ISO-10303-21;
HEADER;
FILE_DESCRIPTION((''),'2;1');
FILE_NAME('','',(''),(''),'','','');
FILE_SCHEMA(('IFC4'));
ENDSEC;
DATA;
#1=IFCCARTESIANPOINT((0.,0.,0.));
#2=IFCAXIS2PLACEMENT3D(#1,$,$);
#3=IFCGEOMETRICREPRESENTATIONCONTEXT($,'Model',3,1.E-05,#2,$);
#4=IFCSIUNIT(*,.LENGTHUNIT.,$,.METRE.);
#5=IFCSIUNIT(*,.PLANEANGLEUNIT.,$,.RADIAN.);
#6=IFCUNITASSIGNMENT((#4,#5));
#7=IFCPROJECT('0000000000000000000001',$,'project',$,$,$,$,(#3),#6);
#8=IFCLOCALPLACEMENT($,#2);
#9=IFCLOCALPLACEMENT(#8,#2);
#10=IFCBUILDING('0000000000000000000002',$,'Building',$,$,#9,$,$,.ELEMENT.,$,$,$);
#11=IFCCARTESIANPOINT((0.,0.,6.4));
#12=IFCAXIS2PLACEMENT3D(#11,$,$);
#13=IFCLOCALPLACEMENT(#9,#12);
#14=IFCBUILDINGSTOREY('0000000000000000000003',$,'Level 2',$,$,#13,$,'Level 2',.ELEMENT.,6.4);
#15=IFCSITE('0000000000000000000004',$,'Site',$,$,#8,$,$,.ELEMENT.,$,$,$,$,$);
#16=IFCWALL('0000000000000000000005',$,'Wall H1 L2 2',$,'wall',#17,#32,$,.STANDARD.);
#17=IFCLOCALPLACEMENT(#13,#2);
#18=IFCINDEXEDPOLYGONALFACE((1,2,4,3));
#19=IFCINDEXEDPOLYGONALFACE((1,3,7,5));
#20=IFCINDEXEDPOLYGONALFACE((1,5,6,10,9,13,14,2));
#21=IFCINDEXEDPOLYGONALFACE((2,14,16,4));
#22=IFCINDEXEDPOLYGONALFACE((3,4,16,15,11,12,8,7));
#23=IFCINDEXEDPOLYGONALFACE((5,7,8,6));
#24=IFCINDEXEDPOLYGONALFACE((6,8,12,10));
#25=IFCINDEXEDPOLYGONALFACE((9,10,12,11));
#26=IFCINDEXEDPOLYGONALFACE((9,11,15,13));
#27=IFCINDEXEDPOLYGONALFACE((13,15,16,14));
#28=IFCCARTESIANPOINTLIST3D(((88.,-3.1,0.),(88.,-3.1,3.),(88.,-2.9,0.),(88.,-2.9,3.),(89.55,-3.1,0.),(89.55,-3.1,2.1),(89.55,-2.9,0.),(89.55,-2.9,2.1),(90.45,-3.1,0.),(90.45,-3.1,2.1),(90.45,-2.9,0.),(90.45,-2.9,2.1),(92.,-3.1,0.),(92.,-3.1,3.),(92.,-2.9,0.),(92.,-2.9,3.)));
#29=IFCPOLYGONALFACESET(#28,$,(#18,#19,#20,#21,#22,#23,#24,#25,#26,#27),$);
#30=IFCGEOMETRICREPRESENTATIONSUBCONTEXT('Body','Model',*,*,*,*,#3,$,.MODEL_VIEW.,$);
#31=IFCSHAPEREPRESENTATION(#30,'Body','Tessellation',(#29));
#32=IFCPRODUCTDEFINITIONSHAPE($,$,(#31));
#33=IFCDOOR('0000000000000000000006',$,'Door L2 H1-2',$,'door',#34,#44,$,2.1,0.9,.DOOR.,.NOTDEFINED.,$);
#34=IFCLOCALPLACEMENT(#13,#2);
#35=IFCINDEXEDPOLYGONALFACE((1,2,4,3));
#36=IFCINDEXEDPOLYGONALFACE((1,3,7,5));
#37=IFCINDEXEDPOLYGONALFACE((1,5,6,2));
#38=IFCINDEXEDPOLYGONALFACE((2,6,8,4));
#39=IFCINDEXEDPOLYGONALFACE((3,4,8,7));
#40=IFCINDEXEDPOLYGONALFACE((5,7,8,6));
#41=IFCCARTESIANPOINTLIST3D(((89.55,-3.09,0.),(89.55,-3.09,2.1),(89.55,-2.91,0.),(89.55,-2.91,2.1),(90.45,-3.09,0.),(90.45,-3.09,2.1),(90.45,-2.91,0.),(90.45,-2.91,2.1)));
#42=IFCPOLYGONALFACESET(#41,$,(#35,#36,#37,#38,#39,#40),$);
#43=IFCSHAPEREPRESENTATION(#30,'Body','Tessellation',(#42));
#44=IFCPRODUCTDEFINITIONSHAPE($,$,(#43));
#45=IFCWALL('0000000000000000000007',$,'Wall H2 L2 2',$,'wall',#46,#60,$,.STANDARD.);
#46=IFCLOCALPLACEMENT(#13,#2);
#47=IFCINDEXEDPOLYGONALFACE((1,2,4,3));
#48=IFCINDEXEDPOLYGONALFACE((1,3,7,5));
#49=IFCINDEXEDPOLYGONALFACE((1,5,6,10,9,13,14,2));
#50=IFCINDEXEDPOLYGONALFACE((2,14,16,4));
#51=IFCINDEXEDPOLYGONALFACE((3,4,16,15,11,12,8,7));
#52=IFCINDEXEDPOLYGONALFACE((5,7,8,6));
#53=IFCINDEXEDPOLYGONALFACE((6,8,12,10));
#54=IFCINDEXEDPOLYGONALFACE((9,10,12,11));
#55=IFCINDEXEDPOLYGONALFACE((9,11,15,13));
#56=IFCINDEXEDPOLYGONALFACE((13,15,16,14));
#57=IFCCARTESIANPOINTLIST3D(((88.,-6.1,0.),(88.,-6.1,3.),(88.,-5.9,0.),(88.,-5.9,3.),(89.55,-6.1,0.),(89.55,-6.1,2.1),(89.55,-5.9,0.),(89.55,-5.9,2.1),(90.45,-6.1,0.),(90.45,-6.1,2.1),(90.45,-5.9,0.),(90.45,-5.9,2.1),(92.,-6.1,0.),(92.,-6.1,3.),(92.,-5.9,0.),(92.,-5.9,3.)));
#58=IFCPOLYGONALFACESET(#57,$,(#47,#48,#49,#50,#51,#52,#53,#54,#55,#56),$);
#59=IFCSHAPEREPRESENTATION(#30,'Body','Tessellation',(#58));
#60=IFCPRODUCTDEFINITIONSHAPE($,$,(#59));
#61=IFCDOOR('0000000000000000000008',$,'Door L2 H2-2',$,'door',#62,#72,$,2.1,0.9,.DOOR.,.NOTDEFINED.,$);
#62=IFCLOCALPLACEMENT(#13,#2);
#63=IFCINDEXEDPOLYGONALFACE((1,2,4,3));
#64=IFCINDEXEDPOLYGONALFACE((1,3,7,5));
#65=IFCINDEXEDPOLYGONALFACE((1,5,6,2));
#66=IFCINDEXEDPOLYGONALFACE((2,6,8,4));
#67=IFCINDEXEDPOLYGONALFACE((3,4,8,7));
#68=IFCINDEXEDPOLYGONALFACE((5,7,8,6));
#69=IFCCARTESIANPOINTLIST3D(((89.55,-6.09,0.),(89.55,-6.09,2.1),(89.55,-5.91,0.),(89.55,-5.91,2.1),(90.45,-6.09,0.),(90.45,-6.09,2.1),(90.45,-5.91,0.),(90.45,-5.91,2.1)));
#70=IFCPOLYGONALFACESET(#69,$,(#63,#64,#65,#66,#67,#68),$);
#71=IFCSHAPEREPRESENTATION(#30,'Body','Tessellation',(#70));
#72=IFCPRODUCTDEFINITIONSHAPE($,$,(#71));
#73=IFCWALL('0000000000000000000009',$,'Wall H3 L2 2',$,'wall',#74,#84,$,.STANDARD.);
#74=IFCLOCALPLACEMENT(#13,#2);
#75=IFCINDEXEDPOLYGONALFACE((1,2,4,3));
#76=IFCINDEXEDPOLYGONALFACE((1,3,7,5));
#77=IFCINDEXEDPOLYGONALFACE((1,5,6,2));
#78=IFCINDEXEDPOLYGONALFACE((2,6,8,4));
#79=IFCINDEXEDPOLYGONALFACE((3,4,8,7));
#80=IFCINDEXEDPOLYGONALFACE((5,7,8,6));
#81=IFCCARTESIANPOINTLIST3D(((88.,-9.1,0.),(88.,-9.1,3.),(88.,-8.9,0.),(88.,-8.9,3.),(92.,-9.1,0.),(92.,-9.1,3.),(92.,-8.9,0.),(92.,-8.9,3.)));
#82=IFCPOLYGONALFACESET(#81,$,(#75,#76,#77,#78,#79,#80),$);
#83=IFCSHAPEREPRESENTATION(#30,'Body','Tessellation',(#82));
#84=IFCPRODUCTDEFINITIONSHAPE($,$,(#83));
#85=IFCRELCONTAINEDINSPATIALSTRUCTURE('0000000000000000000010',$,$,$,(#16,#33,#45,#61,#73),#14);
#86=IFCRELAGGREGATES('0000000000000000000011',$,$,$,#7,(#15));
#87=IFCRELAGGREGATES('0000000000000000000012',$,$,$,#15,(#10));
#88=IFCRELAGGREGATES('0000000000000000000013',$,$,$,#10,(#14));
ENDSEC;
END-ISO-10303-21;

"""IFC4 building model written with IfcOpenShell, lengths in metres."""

from ifc_helpers import new_model, si_unit, frame, frame_2d, origin, origin_2d, place, context, subcontext, project, spatial, rectangle, extrude, element, fill, save


model = new_model("IFC4")

# Units and contexts
model_context = context("Model", 3, precision=1e-05, world=origin())
body_context = subcontext(model_context, "Body", "Model", "MODEL_VIEW")
ifc_project = project(units=[si_unit("LENGTHUNIT", "METRE"), si_unit("PLANEANGLEUNIT", "RADIAN")], contexts=[model_context])

# Site, building, storey
site_placement = place(None, origin())
site = spatial("IfcSite", under=ifc_project, at=site_placement, Name="Site", CompositionType="ELEMENT")
building_placement = place(site_placement, origin())
building = spatial("IfcBuilding", under=site, at=building_placement, Name="Building", CompositionType="ELEMENT")
storey_placement = place(building_placement, frame((0.0, 0.0, 6.4)))
storey = spatial("IfcBuildingStorey", under=building, at=storey_placement, Name="Level 2", LongName="Level 2", CompositionType="ELEMENT", Elevation=6.4)

# Walls, openings, doors
wall_1_placement = place(storey_placement, frame((88.0, -3.0, 0.0), z_axis=(0.0, 0.0, 1.0), x_axis=(1.0, 0.0, 0.0)))
wall_1 = element("IfcWall", 1, at=wall_1_placement, inside=storey, Name="Wall H1 L2 2", ObjectType="wall", PredefinedType="STANDARD", context=body_context, shape_type="SweptSolid", body=[
    extrude(rectangle(XDim=4.0, YDim=0.2, at=frame_2d((2.0, 0.0))), origin(), (0.0, 0.0, 1.0), 3.0),
])
opening_1_placement = place(storey_placement, frame((90.0, -3.0, 0.0), z_axis=(0.0, 0.0, 1.0), x_axis=(1.0, 0.0, 0.0)))
opening_1 = element("IfcOpeningElement", 2, at=opening_1_placement, cuts=wall_1, ObjectType="Opening", PredefinedType="OPENING", context=body_context, shape_type="SweptSolid", body=[
    extrude(rectangle(XDim=0.9, YDim=0.22, at=origin_2d()), origin(), (0.0, 0.0, 1.0), 2.1),
])
door_1_placement = place(storey_placement, frame((90.0, -3.0, 0.0), z_axis=(0.0, 0.0, 1.0), x_axis=(1.0, 0.0, 0.0)))
door_1 = element("IfcDoor", 3, at=door_1_placement, inside=storey, Name="Door L2 H1-2", ObjectType="door", OperationType="NOTDEFINED", OverallHeight=2.1, OverallWidth=0.9, PredefinedType="DOOR", context=body_context, shape_type="SweptSolid", body=[
    extrude(rectangle(XDim=0.9, YDim=0.18, at=origin_2d()), origin(), (0.0, 0.0, 1.0), 2.1),
])
fill(opening_1, door_1)
wall_2_placement = place(storey_placement, frame((88.0, -6.0, 0.0), z_axis=(0.0, 0.0, 1.0), x_axis=(1.0, 0.0, 0.0)))
wall_2 = element("IfcWall", 4, at=wall_2_placement, inside=storey, Name="Wall H2 L2 2", ObjectType="wall", PredefinedType="STANDARD", context=body_context, shape_type="SweptSolid", body=[
    extrude(rectangle(XDim=4.0, YDim=0.2, at=frame_2d((2.0, 0.0))), origin(), (0.0, 0.0, 1.0), 3.0),
])
opening_2_placement = place(storey_placement, frame((90.0, -6.0, 0.0), z_axis=(0.0, 0.0, 1.0), x_axis=(1.0, 0.0, 0.0)))
opening_2 = element("IfcOpeningElement", 5, at=opening_2_placement, cuts=wall_2, ObjectType="Opening", PredefinedType="OPENING", context=body_context, shape_type="SweptSolid", body=[
    extrude(rectangle(XDim=0.9, YDim=0.22, at=origin_2d()), origin(), (0.0, 0.0, 1.0), 2.1),
])
door_2_placement = place(storey_placement, frame((90.0, -6.0, 0.0), z_axis=(0.0, 0.0, 1.0), x_axis=(1.0, 0.0, 0.0)))
door_2 = element("IfcDoor", 6, at=door_2_placement, inside=storey, Name="Door L2 H2-2", ObjectType="door", OperationType="NOTDEFINED", OverallHeight=2.1, OverallWidth=0.9, PredefinedType="DOOR", context=body_context, shape_type="SweptSolid", body=[
    extrude(rectangle(XDim=0.9, YDim=0.18, at=origin_2d()), origin(), (0.0, 0.0, 1.0), 2.1),
])
fill(opening_2, door_2)

# Wall
wall_3_placement = place(storey_placement, frame((88.0, -9.0, 0.0), z_axis=(0.0, 0.0, 1.0), x_axis=(1.0, 0.0, 0.0)))
element("IfcWall", 7, at=wall_3_placement, inside=storey, Name="Wall H3 L2 2", ObjectType="wall", PredefinedType="STANDARD", context=body_context, shape_type="SweptSolid", body=[
    extrude(rectangle(XDim=4.0, YDim=0.2, at=frame_2d((2.0, 0.0))), origin(), (0.0, 0.0, 1.0), 3.0),
])

save(model, "model.ifc")
